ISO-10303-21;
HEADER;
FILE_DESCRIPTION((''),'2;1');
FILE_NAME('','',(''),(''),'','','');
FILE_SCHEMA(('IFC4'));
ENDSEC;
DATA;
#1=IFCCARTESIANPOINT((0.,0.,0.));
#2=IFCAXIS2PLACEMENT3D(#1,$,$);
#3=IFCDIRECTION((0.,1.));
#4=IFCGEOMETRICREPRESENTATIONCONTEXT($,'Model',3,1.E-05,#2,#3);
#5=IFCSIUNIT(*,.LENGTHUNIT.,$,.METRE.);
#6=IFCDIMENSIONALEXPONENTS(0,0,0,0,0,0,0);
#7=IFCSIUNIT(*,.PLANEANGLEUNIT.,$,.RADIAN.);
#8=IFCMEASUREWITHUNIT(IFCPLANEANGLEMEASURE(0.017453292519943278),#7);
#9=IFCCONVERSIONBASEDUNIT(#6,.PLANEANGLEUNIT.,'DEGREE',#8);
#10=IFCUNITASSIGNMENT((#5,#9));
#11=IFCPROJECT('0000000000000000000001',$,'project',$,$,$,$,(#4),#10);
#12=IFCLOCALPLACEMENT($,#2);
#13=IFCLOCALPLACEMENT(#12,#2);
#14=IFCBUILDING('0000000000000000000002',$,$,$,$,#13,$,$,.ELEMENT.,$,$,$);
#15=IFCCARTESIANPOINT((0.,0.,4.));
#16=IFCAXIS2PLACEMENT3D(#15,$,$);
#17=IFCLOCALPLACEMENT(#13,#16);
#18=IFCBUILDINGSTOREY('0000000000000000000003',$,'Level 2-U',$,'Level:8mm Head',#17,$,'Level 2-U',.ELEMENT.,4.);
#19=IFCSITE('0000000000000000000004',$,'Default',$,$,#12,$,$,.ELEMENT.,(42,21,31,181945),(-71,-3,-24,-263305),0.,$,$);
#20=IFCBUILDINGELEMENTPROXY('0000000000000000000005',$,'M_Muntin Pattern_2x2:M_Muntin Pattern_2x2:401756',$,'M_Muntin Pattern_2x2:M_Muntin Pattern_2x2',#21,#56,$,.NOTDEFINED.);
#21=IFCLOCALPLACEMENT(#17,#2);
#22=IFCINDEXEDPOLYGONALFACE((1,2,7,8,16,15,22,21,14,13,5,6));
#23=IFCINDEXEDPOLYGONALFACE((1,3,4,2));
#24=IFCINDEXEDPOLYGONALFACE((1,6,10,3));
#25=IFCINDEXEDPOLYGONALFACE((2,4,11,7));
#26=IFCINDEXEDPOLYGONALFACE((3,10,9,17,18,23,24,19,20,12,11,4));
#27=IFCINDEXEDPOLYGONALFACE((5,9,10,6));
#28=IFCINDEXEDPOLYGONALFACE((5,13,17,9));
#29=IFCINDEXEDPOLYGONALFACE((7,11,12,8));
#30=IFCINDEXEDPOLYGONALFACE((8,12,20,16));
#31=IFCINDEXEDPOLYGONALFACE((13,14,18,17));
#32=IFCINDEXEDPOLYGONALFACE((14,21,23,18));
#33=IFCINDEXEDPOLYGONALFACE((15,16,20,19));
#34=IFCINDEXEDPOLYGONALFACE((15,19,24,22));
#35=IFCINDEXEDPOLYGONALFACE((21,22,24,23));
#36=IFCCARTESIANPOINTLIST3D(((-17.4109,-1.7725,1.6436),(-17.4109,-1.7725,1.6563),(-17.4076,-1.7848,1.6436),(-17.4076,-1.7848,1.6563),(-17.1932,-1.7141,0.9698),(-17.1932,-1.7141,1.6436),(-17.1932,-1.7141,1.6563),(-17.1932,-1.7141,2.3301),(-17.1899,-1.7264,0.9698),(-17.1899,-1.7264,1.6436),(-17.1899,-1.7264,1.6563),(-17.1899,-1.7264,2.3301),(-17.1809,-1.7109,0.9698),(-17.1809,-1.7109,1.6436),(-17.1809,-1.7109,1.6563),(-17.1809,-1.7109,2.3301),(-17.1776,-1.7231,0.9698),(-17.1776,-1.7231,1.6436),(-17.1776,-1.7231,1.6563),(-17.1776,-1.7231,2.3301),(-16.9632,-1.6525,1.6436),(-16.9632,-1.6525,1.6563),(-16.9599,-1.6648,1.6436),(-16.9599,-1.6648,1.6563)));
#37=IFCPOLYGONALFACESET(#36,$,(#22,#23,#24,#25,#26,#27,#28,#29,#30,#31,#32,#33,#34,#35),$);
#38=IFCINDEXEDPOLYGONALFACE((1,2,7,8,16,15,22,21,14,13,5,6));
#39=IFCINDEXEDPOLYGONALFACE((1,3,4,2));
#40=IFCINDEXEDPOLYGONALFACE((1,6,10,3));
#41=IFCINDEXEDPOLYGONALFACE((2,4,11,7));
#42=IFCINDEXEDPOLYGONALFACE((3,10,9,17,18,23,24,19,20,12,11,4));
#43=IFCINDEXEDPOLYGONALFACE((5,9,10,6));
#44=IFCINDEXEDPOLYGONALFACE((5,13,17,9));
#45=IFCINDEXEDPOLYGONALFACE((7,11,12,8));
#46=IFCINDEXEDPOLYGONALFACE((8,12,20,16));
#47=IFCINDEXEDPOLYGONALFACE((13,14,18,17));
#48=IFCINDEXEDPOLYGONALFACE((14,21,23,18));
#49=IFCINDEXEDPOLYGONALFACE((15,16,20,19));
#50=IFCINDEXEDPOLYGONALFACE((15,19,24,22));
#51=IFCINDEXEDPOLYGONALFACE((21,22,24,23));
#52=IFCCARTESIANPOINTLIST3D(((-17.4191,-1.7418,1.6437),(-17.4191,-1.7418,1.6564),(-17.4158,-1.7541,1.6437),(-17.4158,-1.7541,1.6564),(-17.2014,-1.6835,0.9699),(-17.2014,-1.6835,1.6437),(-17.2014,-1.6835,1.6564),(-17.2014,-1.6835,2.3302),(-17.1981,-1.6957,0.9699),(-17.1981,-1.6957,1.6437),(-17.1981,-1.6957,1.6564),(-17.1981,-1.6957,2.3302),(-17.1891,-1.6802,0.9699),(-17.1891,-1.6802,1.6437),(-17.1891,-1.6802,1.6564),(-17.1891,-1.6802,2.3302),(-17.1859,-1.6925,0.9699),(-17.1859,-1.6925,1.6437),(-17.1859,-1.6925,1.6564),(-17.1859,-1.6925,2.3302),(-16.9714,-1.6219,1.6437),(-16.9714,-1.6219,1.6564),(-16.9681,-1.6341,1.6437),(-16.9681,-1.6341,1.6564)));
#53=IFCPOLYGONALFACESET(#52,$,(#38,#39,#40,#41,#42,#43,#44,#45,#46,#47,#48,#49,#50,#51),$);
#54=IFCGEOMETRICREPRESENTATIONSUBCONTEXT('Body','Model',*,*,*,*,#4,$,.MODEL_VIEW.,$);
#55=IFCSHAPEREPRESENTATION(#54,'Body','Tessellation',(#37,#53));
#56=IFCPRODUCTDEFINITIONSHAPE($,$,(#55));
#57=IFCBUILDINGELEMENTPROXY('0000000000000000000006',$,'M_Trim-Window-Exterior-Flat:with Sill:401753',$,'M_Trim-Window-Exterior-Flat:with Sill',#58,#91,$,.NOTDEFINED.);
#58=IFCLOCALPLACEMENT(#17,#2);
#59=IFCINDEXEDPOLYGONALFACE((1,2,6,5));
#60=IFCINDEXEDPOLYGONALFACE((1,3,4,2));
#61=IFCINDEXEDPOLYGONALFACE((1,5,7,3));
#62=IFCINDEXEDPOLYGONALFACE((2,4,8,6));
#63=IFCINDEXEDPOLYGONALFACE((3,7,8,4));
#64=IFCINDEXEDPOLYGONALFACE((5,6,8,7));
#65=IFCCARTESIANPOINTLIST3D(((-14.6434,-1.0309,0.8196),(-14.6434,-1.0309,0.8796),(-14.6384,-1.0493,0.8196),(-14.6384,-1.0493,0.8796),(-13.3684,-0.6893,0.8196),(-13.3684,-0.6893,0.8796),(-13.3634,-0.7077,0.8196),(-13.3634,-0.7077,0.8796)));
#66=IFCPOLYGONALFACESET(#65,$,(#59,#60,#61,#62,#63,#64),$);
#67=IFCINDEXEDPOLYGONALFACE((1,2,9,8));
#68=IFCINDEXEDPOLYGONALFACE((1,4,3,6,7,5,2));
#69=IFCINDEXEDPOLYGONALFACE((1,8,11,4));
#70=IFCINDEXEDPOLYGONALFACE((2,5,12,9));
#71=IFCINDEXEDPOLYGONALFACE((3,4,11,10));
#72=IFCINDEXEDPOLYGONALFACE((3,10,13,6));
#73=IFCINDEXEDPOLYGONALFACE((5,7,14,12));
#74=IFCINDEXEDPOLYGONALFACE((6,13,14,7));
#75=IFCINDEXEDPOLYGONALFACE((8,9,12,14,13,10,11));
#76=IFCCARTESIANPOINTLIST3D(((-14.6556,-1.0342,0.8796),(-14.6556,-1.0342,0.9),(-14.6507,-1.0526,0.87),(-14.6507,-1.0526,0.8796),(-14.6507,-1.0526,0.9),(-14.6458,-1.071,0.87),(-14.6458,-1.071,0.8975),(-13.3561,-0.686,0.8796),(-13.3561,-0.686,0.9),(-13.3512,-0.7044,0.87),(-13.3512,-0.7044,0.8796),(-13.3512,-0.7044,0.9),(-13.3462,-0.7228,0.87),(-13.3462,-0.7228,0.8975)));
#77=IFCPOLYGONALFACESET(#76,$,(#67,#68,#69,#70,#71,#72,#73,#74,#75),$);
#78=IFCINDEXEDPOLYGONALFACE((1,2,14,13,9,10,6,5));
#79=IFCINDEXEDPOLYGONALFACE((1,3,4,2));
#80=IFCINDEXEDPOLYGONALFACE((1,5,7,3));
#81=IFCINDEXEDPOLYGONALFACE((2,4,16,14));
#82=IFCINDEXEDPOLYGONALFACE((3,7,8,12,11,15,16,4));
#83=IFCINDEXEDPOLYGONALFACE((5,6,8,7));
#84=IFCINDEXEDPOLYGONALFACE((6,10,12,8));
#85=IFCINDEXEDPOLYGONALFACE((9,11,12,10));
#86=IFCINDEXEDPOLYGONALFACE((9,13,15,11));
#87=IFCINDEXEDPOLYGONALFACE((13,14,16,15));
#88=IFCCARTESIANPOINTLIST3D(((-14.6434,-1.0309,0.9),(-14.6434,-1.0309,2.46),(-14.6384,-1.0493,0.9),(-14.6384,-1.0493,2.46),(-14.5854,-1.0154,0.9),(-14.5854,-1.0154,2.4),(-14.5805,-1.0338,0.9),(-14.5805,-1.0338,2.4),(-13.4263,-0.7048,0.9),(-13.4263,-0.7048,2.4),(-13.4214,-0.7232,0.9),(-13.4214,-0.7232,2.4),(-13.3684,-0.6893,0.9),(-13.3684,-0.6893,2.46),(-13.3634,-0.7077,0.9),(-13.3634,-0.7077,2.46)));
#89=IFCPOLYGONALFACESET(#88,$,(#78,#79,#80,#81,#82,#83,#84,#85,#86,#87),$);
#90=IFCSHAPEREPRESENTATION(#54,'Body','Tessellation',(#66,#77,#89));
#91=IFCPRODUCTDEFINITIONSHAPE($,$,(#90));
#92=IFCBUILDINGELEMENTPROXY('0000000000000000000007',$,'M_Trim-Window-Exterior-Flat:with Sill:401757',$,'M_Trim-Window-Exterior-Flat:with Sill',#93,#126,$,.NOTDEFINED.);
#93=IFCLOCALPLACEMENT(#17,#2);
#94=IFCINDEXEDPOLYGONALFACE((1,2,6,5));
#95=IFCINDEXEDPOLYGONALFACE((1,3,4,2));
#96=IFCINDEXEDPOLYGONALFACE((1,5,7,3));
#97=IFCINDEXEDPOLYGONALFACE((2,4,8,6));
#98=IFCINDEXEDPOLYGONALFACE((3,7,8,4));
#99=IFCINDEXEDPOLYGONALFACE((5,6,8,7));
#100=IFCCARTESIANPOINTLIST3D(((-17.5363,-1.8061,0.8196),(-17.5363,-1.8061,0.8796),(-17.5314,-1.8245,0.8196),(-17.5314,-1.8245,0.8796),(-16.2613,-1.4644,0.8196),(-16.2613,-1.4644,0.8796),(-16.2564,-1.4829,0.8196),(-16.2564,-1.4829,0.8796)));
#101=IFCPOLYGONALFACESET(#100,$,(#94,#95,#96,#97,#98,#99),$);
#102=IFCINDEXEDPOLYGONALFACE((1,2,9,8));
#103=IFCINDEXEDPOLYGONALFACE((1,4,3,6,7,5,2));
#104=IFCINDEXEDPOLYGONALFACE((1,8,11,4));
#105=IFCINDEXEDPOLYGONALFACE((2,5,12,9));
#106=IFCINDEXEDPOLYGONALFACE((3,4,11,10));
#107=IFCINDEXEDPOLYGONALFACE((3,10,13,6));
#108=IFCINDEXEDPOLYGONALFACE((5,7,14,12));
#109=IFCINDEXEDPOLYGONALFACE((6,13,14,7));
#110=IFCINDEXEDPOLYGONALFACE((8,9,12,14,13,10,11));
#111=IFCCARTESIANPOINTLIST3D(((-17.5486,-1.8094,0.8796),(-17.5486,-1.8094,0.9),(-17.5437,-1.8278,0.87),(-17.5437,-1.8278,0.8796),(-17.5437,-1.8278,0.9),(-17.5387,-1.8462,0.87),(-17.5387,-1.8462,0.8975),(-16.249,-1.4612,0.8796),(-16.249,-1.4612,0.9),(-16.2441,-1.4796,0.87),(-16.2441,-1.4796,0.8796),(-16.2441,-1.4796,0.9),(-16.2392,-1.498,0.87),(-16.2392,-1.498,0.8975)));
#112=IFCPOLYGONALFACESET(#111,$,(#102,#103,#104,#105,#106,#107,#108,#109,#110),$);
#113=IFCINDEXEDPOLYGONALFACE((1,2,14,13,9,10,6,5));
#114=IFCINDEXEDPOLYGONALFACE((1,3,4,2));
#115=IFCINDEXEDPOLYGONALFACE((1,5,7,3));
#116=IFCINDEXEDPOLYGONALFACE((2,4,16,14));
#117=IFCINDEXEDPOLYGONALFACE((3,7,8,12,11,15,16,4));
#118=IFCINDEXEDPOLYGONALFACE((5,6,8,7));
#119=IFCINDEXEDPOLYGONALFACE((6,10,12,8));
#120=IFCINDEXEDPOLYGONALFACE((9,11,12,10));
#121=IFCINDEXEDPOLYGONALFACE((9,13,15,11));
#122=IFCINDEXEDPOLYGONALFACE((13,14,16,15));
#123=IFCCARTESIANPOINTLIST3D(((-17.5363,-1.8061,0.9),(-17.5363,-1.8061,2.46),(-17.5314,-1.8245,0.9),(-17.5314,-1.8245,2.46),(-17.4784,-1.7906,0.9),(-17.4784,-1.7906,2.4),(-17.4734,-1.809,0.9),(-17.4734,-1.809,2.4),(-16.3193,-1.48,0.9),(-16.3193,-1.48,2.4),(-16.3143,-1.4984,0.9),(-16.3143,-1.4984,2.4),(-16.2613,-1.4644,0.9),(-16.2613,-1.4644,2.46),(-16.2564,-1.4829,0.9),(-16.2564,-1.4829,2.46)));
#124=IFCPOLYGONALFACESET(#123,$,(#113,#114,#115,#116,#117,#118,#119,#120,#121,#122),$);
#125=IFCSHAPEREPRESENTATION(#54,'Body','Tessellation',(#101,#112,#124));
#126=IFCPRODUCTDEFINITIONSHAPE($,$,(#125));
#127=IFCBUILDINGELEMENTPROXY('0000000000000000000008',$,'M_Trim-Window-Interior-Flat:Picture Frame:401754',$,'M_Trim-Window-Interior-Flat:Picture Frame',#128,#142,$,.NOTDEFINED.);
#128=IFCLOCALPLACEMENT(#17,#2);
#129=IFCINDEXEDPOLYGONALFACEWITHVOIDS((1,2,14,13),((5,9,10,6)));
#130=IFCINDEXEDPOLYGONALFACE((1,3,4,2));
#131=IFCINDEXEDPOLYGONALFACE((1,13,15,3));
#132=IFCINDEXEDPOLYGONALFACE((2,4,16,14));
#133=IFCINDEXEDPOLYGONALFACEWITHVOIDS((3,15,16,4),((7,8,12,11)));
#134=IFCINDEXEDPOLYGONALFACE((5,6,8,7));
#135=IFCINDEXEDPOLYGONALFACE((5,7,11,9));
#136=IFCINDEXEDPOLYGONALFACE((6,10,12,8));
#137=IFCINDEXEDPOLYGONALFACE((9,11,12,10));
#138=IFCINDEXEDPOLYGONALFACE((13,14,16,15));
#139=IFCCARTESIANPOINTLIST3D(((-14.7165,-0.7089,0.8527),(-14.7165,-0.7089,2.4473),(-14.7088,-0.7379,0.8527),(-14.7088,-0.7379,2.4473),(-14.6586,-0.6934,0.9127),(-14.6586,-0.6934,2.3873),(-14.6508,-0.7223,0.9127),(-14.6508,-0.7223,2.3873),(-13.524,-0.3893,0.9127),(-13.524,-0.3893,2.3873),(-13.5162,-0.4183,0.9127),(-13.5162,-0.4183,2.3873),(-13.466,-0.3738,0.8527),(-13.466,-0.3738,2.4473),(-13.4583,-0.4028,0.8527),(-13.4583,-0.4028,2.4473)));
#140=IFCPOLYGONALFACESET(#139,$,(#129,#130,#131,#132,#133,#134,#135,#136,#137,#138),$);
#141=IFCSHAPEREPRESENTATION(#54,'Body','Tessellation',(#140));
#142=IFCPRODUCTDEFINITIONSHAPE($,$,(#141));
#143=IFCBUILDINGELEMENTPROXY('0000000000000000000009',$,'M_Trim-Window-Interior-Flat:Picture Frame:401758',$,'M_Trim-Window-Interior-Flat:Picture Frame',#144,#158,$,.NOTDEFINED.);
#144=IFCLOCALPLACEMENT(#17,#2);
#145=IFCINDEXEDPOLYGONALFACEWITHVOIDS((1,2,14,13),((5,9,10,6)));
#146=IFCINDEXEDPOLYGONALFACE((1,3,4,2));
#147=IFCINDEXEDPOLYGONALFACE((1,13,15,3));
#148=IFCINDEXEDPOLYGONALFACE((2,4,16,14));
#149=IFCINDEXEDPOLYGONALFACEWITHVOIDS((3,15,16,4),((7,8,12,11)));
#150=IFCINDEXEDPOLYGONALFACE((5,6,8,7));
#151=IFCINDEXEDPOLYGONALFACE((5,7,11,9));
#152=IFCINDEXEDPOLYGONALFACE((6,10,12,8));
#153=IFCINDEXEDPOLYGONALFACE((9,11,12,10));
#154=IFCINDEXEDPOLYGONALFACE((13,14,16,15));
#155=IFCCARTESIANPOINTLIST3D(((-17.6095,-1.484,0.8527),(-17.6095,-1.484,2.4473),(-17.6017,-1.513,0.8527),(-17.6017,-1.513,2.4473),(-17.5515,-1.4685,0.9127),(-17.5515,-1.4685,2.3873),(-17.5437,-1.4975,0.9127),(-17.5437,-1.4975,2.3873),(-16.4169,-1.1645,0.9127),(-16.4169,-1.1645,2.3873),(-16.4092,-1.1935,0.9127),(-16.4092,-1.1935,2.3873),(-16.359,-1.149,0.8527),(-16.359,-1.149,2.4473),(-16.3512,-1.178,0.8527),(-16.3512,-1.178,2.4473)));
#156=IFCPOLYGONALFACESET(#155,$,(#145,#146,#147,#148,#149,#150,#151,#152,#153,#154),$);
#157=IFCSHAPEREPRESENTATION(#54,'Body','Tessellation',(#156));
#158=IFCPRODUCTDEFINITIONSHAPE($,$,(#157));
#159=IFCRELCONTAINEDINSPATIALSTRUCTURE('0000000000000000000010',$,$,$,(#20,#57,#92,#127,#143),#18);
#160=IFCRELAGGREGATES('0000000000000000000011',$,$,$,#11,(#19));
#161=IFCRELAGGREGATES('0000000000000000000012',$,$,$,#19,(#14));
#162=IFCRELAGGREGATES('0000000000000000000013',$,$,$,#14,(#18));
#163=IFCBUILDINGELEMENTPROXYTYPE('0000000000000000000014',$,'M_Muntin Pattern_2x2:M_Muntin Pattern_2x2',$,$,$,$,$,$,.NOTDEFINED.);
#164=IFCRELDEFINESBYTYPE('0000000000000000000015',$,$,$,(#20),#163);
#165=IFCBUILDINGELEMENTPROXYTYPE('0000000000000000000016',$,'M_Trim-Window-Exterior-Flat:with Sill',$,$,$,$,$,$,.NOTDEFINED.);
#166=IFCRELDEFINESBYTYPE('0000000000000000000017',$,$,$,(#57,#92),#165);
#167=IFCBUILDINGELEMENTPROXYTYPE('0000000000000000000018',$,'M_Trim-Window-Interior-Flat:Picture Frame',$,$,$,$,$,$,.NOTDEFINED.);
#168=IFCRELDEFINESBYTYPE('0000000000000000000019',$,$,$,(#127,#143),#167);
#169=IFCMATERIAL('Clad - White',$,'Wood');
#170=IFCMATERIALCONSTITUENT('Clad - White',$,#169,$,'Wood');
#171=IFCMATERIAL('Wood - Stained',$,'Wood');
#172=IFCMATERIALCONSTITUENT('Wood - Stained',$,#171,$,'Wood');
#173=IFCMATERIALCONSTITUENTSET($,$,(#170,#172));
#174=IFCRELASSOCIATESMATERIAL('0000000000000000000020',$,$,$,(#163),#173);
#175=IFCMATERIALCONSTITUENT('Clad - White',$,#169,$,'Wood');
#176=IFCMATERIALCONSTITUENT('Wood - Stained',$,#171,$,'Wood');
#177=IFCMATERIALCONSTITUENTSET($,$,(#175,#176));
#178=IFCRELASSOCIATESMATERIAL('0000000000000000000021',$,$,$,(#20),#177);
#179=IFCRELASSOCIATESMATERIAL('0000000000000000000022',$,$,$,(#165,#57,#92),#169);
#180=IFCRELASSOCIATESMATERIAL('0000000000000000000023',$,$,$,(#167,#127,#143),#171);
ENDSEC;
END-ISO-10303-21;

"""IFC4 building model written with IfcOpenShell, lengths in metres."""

from ifc_helpers import new_model, entity, si_unit, converted_unit, direction, frame, origin, place, context, subcontext, project, spatial, indexed_curve, outline, extrude, source, transform, mapped, material, constituent, constituent_set, type_object, type_shapes, element, save


model = new_model("IFC4")

# Units and contexts
model_context = context("Model", 3, precision=1e-05, world=origin(), true_north=direction((0.0, 1.0)))
body_context = subcontext(model_context, "Body", "Model", "MODEL_VIEW")
ifc_project = project(units=[si_unit("LENGTHUNIT", "METRE"), converted_unit("PLANEANGLEUNIT", "DEGREE", entity("IfcPlaneAngleMeasure", 0.017453292519943278), si_unit("PLANEANGLEUNIT", "RADIAN"), dimensions=[0, 0, 0, 0, 0, 0, 0])], contexts=[model_context])

# Site, building, storey
site_placement = place(None, origin())
site = spatial("IfcSite", under=ifc_project, at=site_placement, Name="Default", CompositionType="ELEMENT", RefLatitude=(42, 21, 31, 181945), RefLongitude=(-71, -3, -24, -263305), RefElevation=0.0)
building_placement = place(site_placement, origin())
building = spatial("IfcBuilding", under=site, at=building_placement, CompositionType="ELEMENT")
storey_placement = place(building_placement, frame((0.0, 0.0, 4.0)))
storey = spatial("IfcBuildingStorey", under=building, at=storey_placement, Name="Level 2-U", ObjectType="Level:8mm Head", LongName="Level 2-U", CompositionType="ELEMENT", Elevation=4.0)

# Building element proxies
ifc_material_1 = material(Name="Clad - White", Category="Wood")
ifc_material_2 = material(Name="Wood - Stained", Category="Wood")
ifc_constituent_1 = constituent(ifc_material_1, Name="Clad - White", Category="Wood")
ifc_constituent_2 = constituent(ifc_material_2, Name="Wood - Stained", Category="Wood")
ifc_constituent_set_1 = constituent_set(constituents=[ifc_constituent_1, ifc_constituent_2])
building_element_proxy_type_1 = type_object("IfcBuildingElementProxyType", Name="M_Muntin Pattern_2x2:M_Muntin Pattern_2x2", PredefinedType="NOTDEFINED", material=ifc_constituent_set_1)
shared_shape_1 = source(origin(), body_context, "Body", "SweptSolid", [
    extrude(outline(indexed_curve([(0.0064, -0.0064), (0.6801, -0.0064), (0.6801, 0.0063), (0.0064, 0.0063), (0.0064, 0.2317), (-0.0063, 0.2317), (-0.0063, 0.0063), (-0.6802, 0.0063), (-0.6802, -0.0064), (-0.0063, -0.0064), (-0.0063, -0.2317), (0.0064, -0.2317), (0.0064, -0.0064)], self_intersect=False)), frame((0.0, -0.0222, 0.6801), z_axis=(0.0, 1.0, 0.0), x_axis=(0.0, 0.0, 1.0)), (0.0, 0.0, 1.0), 0.0127),
    extrude(outline(indexed_curve([(0.0064, -0.0064), (0.6802, -0.0064), (0.6802, 0.0063), (0.0064, 0.0063), (0.0064, 0.2317), (-0.0063, 0.2317), (-0.0063, 0.0063), (-0.6802, 0.0063), (-0.6802, -0.0064), (-0.0063, -0.0064), (-0.0063, -0.2317), (0.0064, -0.2317), (0.0064, -0.0064)], self_intersect=False)), frame((0.0, 0.0095, 0.6802), z_axis=(0.0, 1.0, 0.0), x_axis=(0.0, 0.0, 1.0)), (0.0, 0.0, 1.0), 0.0127),
])
type_shapes(building_element_proxy_type_1, [shared_shape_1])
ifc_constituent_3 = constituent(ifc_material_1, Name="Clad - White", Category="Wood")
ifc_constituent_4 = constituent(ifc_material_2, Name="Wood - Stained", Category="Wood")
ifc_constituent_set_2 = constituent_set(constituents=[ifc_constituent_3, ifc_constituent_4])
proxy_1_placement = place(storey_placement, frame((-17.1895, -1.7033, 0.9699), z_axis=(0.0, 0.0, 1.0), x_axis=(0.965926, 0.258819, 0.0)))
element("IfcBuildingElementProxy", 1, at=proxy_1_placement, inside=storey, type_object=building_element_proxy_type_1, material=ifc_constituent_set_2, Name="M_Muntin Pattern_2x2:M_Muntin Pattern_2x2:401756", ObjectType="M_Muntin Pattern_2x2:M_Muntin Pattern_2x2", PredefinedType="NOTDEFINED", context=body_context, shape_type="MappedRepresentation", body=[
    mapped(shared_shape_1, transform((0.0, 0.0, 0.0), scale=1.0)),
])
building_element_proxy_type_2 = type_object("IfcBuildingElementProxyType", Name="M_Trim-Window-Exterior-Flat:with Sill", PredefinedType="NOTDEFINED", material=ifc_material_1)
shared_shape_2 = source(origin(), body_context, "Body", "SweptSolid", [
    extrude(outline(indexed_curve([(-0.66, -0.03), (0.66, -0.03), (0.66, 0.03), (-0.66, 0.03), (-0.66, -0.03)], self_intersect=False)), frame((0.0, -1.5504, 0.0), z_axis=(0.0, 0.0, 1.0), x_axis=(-1.0, 0.0, 0.0)), (0.0, 0.0, 1.0), 0.019),
    extrude(outline(indexed_curve([(-0.019, -0.0152), (0.0, -0.0152), (0.0, -0.0057), (0.019, -0.0057), (0.019, 0.0148), (0.0, 0.0148), (-0.019, 0.0123), (-0.019, -0.0152)], self_intersect=False)), frame((-0.6727, -1.5148, 0.019), z_axis=(1.0, 0.0, 0.0), x_axis=(0.0, 0.0, -1.0)), (0.0, 0.0, 1.0), 1.3454),
    extrude(outline(indexed_curve([(-0.795, -0.66), (0.765, -0.66), (0.765, -0.6), (-0.735, -0.6), (-0.735, 0.6), (0.765, 0.6), (0.765, 0.66), (-0.795, 0.66), (-0.795, -0.66)], self_intersect=False)), frame((0.0, -0.735, 0.0), z_axis=(0.0, 0.0, 1.0), x_axis=(0.0, -1.0, 0.0)), (0.0, 0.0, 1.0), 0.019),
])
type_shapes(building_element_proxy_type_2, [shared_shape_2])
for number, where, z_axis, x_axis, name in (
    (2, (-14.0059, -0.8601, 2.4), (0.258819, -0.965926, 0.0), (0.965926, 0.258819, 0.0), "M_Trim-Window-Exterior-Flat:with Sill:401753"),
    (3, (-16.8988, -1.6353, 2.4), (0.258819, -0.965926, 0.0), (0.965926, 0.258819, 0.0), "M_Trim-Window-Exterior-Flat:with Sill:401757"),
):
    element("IfcBuildingElementProxy", number, at=place(storey_placement, frame(where, z_axis=z_axis, x_axis=x_axis)), inside=storey, type_object=building_element_proxy_type_2, material=ifc_material_1, Name=name, ObjectType="M_Trim-Window-Exterior-Flat:with Sill", PredefinedType="NOTDEFINED", context=body_context, shape_type="MappedRepresentation", body=[
        mapped(shared_shape_2, transform((0.0, 0.0, 0.0), scale=1.0)),
    ])
building_element_proxy_type_3 = type_object("IfcBuildingElementProxyType", Name="M_Trim-Window-Interior-Flat:Picture Frame", PredefinedType="NOTDEFINED", material=ifc_material_2)
shared_shape_3 = source(origin(), body_context, "Body", "SweptSolid", [
    extrude(outline(indexed_curve([(-0.6473, -0.7973), (0.6473, -0.7973), (0.6473, 0.7973), (-0.6473, 0.7973), (-0.6473, -0.7973)], self_intersect=False), holes=[indexed_curve([(-0.5873, -0.7373), (-0.5873, 0.7373), (0.5873, 0.7373), (0.5873, -0.7373), (-0.5873, -0.7373)], self_intersect=False)]), frame((0.0, -0.75, 0.0), z_axis=(0.0, 0.0, 1.0), x_axis=(-1.0, 0.0, 0.0)), (0.0, 0.0, 1.0), 0.03),
])
type_shapes(building_element_proxy_type_3, [shared_shape_3])
for number, where, z_axis, x_axis, name in (
    (4, (-14.0835, -0.5703, 2.4), (-0.258819, 0.965926, 0.0), (-0.965926, -0.258819, 0.0), "M_Trim-Window-Interior-Flat:Picture Frame:401754"),
    (5, (-16.9765, -1.3455, 2.4), (-0.258819, 0.965926, 0.0), (-0.965926, -0.258819, 0.0), "M_Trim-Window-Interior-Flat:Picture Frame:401758"),
):
    element("IfcBuildingElementProxy", number, at=place(storey_placement, frame(where, z_axis=z_axis, x_axis=x_axis)), inside=storey, type_object=building_element_proxy_type_3, material=ifc_material_2, Name=name, ObjectType="M_Trim-Window-Interior-Flat:Picture Frame", PredefinedType="NOTDEFINED", context=body_context, shape_type="MappedRepresentation", body=[
        mapped(shared_shape_3, transform((0.0, 0.0, 0.0), scale=1.0)),
    ])

save(model, "model.ifc")
